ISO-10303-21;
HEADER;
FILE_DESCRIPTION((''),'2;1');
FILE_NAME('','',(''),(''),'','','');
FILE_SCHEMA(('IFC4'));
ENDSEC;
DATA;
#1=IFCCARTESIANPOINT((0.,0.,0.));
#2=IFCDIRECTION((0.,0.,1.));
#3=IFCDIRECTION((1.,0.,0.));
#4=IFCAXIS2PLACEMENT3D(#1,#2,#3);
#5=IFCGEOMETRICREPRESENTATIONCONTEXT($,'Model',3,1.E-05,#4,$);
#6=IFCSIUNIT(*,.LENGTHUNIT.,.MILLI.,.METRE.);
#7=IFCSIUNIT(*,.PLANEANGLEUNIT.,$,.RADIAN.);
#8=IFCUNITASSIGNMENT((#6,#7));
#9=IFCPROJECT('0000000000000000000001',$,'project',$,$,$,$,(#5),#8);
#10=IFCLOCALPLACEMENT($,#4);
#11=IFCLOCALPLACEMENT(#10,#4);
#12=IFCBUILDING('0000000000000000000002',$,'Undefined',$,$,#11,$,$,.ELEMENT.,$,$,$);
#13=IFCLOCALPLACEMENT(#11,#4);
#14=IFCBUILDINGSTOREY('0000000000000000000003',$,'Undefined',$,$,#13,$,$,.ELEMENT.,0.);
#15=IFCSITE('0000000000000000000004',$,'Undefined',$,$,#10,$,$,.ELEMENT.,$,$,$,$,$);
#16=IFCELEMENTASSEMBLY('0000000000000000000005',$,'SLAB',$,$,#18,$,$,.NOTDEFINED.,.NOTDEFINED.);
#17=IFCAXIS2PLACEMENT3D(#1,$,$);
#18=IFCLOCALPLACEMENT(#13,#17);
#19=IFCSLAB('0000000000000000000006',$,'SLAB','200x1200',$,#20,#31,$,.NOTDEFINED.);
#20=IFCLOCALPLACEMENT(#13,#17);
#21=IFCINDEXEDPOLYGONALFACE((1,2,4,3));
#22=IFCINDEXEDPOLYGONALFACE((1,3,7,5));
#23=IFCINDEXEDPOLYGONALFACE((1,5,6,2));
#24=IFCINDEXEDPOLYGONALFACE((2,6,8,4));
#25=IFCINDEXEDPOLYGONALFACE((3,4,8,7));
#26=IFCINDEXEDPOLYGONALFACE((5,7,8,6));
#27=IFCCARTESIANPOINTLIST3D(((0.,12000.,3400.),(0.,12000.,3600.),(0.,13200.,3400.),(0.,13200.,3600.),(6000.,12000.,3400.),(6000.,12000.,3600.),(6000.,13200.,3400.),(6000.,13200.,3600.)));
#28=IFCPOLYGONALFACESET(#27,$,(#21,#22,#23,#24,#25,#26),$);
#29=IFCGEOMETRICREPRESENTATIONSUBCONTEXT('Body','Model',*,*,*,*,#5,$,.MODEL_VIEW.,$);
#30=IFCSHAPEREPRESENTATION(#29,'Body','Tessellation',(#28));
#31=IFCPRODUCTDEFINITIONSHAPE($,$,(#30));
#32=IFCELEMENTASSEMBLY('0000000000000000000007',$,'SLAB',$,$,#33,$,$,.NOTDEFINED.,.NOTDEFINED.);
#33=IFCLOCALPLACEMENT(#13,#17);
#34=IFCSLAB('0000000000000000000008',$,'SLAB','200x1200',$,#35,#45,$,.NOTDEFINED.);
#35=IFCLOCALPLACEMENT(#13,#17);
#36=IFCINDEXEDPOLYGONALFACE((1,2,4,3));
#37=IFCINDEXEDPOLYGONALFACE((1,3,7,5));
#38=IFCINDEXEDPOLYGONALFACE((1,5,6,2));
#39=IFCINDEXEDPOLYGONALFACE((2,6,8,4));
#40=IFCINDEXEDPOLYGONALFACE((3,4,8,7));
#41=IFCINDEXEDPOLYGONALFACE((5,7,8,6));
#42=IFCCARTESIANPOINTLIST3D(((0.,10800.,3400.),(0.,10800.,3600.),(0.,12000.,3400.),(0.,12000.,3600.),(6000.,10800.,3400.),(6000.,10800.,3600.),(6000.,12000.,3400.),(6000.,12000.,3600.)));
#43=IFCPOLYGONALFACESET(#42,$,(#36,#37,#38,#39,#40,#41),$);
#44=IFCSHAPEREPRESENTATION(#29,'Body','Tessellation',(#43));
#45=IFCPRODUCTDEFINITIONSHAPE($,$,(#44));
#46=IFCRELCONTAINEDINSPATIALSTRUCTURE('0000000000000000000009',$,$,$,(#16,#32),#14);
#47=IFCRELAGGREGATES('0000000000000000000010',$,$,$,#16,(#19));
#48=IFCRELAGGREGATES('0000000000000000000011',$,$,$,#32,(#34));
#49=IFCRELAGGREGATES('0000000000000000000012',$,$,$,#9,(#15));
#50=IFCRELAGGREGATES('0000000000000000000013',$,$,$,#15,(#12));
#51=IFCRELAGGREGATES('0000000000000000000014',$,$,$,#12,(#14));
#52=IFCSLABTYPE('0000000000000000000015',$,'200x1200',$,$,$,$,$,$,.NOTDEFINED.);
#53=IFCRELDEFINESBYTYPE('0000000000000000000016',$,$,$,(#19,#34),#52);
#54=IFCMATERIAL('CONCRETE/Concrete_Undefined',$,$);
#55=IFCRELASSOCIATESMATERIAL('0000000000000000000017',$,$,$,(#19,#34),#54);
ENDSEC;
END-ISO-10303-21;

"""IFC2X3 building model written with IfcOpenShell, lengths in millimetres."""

from ifc_helpers import new_model, si_unit, frame, origin_with_axes, place, context, subcontext, project, spatial, polyline, outline, extrude, material, type_object, element, aggregate, save


model = new_model("IFC2X3")

# Units and contexts
model_context = context("Model", 3, precision=1e-05, world=origin_with_axes())
body_context = subcontext(model_context, "Body", "Model", "MODEL_VIEW")
ifc_project = project(units=[si_unit("LENGTHUNIT", "METRE", prefix="MILLI"), si_unit("PLANEANGLEUNIT", "RADIAN")], contexts=[model_context])

# Site, building, storey
site_placement = place(None, origin_with_axes())
site = spatial("IfcSite", under=ifc_project, at=site_placement, Name="Undefined", CompositionType="ELEMENT")
building_placement = place(site_placement, origin_with_axes())
building = spatial("IfcBuilding", under=site, at=building_placement, Name="Undefined", CompositionType="ELEMENT")
storey_placement = place(building_placement, origin_with_axes())
storey = spatial("IfcBuildingStorey", under=building, at=storey_placement, Name="Undefined", CompositionType="ELEMENT", Elevation=0.0)

# Shared definitions
ifc_material_1 = material(Name="CONCRETE/Concrete_Undefined")

# Element assemblies, slabs
assembly_1_placement = place(storey_placement, origin_with_axes())
assembly_1 = element("IfcElementAssembly", 1, at=assembly_1_placement, inside=storey, Name="SLAB", AssemblyPlace="NOTDEFINED", PredefinedType="NOTDEFINED")
slab_type = type_object("IfcSlabType", Name="200x1200", PredefinedType="NOTDEFINED")
slab_1_placement = place(assembly_1_placement, frame((6000.0, 12000.0, 3500.0), z_axis=(0.0, 0.0, 1.0), x_axis=(0.0, 1.0, 0.0)))
slab_1 = element("IfcSlab", 2, at=slab_1_placement, type_object=slab_type, material=ifc_material_1, Name="SLAB", Description="200x1200", PredefinedType="NOTDEFINED", context=body_context, shape_type="SweptSolid", body=[
    extrude(outline(polyline([(0.0, 0.0), (1200.0, 0.0), (1200.0, 6000.0), (0.0, 6000.0), (0.0, 0.0)])), frame((0.0, 0.0, -100.0), z_axis=(0.0, 0.0, 1.0), x_axis=(1.0, 0.0, 0.0)), (0.0, 0.0, 1.0), 200.0),
])
aggregate(assembly_1, [slab_1])
assembly_2_placement = place(storey_placement, origin_with_axes())
assembly_2 = element("IfcElementAssembly", 3, at=assembly_2_placement, inside=storey, Name="SLAB", AssemblyPlace="NOTDEFINED", PredefinedType="NOTDEFINED")
slab_2_placement = place(assembly_2_placement, frame((6000.0, 10800.0, 3500.0), z_axis=(0.0, 0.0, 1.0), x_axis=(0.0, 1.0, 0.0)))
slab_2 = element("IfcSlab", 4, at=slab_2_placement, type_object=slab_type, material=ifc_material_1, Name="SLAB", Description="200x1200", PredefinedType="NOTDEFINED", context=body_context, shape_type="SweptSolid", body=[
    extrude(outline(polyline([(0.0, 0.0), (1200.0, 0.0), (1200.0, 6000.0), (0.0, 6000.0), (0.0, 0.0)])), frame((0.0, 0.0, -100.0), z_axis=(0.0, 0.0, 1.0), x_axis=(1.0, 0.0, 0.0)), (0.0, 0.0, 1.0), 200.0),
])
aggregate(assembly_2, [slab_2])

save(model, "model.ifc")
